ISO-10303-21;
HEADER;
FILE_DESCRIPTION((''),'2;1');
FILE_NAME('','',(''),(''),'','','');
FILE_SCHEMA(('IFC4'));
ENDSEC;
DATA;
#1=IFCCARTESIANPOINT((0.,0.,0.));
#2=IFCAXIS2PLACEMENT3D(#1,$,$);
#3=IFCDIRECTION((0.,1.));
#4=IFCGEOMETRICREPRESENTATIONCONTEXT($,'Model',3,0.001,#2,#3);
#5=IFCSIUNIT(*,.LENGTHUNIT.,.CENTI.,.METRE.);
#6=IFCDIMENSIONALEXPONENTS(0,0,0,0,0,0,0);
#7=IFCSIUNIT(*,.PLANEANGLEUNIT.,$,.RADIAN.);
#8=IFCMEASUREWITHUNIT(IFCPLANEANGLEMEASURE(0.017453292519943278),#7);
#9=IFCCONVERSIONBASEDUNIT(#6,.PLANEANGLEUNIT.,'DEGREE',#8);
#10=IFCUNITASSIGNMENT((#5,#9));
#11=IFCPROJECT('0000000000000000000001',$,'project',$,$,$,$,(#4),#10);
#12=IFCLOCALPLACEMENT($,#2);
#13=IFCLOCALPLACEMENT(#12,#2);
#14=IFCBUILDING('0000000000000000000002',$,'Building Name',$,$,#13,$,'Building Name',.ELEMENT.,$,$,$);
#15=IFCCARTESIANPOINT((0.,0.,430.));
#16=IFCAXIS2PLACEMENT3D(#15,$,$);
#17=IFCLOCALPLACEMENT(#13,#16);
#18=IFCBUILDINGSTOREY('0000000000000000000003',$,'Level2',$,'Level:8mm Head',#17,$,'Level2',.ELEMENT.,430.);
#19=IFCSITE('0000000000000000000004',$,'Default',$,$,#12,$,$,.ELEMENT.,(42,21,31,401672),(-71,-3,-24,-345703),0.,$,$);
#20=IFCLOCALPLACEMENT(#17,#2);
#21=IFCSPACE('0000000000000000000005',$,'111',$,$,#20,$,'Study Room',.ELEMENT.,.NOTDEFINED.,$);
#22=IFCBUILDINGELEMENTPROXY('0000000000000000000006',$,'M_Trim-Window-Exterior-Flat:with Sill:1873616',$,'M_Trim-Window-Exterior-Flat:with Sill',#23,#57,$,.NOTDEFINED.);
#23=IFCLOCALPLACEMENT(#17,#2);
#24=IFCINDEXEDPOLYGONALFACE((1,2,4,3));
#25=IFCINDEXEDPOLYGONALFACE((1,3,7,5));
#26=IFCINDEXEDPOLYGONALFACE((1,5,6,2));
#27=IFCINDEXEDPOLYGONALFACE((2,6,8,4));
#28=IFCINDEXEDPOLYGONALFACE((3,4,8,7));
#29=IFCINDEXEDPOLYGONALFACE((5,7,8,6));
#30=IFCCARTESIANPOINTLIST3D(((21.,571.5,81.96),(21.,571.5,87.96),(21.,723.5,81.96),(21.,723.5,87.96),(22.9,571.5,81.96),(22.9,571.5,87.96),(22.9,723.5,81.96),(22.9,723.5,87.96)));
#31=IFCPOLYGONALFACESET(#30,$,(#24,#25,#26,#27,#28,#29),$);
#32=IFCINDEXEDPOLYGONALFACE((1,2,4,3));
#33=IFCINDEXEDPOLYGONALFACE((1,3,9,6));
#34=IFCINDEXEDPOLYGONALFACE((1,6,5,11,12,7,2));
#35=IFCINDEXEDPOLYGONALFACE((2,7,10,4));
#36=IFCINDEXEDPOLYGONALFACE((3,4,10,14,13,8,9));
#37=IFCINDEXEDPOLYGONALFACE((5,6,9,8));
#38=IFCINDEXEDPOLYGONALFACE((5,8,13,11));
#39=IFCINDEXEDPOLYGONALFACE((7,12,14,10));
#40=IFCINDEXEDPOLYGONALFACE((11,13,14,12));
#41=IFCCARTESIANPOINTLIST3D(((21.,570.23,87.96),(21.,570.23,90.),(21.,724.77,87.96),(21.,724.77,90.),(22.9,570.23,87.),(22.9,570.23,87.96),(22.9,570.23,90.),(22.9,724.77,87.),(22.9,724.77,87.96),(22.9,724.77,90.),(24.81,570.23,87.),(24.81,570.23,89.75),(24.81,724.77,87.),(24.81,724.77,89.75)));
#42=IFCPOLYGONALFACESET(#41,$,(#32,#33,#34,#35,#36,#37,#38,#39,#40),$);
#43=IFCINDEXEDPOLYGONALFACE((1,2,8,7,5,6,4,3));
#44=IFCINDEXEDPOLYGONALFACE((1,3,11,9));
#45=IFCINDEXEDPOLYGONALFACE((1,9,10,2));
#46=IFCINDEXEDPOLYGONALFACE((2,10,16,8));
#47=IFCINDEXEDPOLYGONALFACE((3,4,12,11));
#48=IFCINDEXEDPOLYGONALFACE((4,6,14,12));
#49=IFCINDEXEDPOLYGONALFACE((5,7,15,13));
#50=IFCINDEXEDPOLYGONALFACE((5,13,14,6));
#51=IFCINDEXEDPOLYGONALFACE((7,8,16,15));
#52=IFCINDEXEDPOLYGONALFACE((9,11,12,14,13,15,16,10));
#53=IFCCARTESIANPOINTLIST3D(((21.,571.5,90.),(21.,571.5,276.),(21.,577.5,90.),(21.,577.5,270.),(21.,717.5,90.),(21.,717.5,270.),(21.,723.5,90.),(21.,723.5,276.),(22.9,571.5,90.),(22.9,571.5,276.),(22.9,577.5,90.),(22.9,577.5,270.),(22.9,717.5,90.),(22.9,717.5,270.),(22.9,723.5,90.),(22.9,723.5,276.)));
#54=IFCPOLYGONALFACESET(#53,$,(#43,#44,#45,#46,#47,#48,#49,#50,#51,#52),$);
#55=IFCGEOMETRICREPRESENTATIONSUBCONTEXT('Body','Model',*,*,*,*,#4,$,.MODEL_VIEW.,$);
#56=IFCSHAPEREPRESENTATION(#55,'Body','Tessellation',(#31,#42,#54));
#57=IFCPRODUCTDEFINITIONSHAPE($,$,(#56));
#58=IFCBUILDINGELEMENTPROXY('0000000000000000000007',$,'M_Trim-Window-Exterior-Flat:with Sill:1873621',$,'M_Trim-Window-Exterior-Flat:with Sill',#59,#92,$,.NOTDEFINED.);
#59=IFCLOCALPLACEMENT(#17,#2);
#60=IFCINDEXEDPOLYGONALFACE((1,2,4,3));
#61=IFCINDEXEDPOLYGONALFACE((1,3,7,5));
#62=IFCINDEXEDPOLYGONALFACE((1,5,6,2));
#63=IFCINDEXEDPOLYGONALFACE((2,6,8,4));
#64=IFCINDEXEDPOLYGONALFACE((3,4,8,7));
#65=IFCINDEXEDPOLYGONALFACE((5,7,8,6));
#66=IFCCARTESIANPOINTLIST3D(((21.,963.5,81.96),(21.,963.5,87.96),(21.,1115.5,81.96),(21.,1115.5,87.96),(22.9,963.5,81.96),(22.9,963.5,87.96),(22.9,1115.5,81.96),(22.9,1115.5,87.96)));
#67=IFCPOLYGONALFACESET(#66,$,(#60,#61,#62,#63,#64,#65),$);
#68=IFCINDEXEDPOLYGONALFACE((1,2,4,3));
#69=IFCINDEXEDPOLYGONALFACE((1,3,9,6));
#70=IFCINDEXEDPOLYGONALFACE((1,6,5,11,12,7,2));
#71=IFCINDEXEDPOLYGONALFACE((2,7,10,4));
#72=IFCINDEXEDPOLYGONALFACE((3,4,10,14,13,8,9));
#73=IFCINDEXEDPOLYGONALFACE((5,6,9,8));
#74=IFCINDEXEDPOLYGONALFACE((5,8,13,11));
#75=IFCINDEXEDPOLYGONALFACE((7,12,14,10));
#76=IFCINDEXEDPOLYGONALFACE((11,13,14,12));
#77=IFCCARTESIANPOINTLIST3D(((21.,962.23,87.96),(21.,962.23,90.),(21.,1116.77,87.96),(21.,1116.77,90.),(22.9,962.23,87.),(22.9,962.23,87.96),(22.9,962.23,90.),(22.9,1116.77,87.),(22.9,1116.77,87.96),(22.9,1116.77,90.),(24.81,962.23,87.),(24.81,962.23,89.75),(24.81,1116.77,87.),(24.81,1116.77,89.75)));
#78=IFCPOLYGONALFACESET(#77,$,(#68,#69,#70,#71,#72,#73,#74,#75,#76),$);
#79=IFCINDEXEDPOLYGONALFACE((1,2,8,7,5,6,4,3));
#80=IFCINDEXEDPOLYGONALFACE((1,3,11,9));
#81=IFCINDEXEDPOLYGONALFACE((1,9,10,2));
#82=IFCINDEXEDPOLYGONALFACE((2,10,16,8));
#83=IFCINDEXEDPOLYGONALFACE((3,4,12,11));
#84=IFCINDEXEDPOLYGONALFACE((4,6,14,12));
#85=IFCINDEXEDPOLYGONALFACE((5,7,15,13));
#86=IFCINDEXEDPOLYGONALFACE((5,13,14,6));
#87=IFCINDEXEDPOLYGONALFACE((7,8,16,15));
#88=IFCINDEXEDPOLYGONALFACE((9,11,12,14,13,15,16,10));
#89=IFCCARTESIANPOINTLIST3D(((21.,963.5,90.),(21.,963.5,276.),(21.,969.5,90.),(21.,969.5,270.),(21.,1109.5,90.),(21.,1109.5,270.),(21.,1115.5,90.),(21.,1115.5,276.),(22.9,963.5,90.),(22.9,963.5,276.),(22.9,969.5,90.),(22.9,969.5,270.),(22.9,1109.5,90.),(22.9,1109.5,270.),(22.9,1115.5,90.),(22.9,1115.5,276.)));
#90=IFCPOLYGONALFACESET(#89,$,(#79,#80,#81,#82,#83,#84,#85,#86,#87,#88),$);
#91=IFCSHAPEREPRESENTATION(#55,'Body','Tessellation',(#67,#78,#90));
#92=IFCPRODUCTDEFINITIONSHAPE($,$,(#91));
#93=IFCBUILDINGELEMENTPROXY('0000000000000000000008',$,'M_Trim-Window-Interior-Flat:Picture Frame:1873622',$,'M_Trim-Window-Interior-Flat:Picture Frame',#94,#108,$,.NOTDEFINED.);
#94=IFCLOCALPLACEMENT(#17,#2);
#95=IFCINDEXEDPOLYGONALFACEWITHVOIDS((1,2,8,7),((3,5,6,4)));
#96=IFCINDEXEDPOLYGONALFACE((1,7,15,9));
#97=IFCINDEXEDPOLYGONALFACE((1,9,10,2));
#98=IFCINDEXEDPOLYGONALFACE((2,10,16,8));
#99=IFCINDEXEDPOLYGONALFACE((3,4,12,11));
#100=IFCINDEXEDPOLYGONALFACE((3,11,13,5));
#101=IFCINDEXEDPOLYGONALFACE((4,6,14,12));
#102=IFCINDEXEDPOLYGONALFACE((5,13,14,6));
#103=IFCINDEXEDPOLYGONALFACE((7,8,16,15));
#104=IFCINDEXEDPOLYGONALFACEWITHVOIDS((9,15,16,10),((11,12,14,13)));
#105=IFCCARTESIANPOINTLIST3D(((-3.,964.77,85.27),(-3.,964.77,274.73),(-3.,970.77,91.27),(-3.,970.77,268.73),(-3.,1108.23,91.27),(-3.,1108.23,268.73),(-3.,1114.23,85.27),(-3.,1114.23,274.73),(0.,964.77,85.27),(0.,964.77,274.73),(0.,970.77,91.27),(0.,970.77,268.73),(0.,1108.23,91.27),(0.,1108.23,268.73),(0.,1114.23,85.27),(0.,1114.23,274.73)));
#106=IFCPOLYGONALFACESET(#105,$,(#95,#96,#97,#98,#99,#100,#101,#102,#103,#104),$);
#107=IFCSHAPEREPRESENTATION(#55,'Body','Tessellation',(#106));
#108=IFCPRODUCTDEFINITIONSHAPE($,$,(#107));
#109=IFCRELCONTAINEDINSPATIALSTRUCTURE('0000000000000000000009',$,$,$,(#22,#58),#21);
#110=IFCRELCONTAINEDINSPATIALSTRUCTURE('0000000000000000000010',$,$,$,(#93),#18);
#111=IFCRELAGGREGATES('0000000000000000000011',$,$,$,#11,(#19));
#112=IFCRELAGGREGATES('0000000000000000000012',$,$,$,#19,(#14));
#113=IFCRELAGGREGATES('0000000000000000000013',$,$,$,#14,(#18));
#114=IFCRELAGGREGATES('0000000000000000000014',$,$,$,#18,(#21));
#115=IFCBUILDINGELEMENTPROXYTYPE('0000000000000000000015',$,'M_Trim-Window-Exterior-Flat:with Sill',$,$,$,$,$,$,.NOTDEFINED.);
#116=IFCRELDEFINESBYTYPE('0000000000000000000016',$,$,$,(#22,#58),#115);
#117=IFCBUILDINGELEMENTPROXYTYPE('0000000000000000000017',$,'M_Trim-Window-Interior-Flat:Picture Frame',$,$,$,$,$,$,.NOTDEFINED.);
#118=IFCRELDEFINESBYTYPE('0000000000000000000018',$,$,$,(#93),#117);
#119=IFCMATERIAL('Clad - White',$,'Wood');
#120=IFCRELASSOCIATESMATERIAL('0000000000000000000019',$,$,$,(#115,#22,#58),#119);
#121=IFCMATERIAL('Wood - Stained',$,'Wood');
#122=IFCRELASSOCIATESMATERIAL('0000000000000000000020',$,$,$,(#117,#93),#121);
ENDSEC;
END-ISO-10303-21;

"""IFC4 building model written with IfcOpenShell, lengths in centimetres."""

from ifc_helpers import new_model, entity, si_unit, converted_unit, direction, frame, origin, place, context, subcontext, project, spatial, indexed_curve, outline, extrude, source, transform, mapped, material, type_object, type_shapes, element, save


model = new_model("IFC4")

# Units and contexts
model_context = context("Model", 3, precision=0.001, world=origin(), true_north=direction((0.0, 1.0)))
body_context = subcontext(model_context, "Body", "Model", "MODEL_VIEW")
ifc_project = project(units=[si_unit("LENGTHUNIT", "METRE", prefix="CENTI"), converted_unit("PLANEANGLEUNIT", "DEGREE", entity("IfcPlaneAngleMeasure", 0.017453292519943278), si_unit("PLANEANGLEUNIT", "RADIAN"), dimensions=[0, 0, 0, 0, 0, 0, 0])], contexts=[model_context])

# Site, building, storey
site_placement = place(None, origin())
site = spatial("IfcSite", under=ifc_project, at=site_placement, Name="Default", CompositionType="ELEMENT", RefLatitude=(42, 21, 31, 401672), RefLongitude=(-71, -3, -24, -345703), RefElevation=0.0)
building_placement = place(site_placement, origin())
building = spatial("IfcBuilding", under=site, at=building_placement, Name="Building Name", LongName="Building Name", CompositionType="ELEMENT")
storey_placement = place(building_placement, frame((0.0, 0.0, 430.0)))
storey = spatial("IfcBuildingStorey", under=building, at=storey_placement, Name="Level2", ObjectType="Level:8mm Head", LongName="Level2", CompositionType="ELEMENT", Elevation=430.0)

# Shared definitions
space_placement = place(storey_placement, origin())
space = spatial("IfcSpace", under=storey, at=space_placement, Name="111", LongName="Study Room", CompositionType="ELEMENT", PredefinedType="NOTDEFINED")

# Building element proxies
ifc_material_1 = material(Name="Clad - White", Category="Wood")
ifc_material_2 = material(Name="Wood - Stained", Category="Wood")
building_element_proxy_type_1 = type_object("IfcBuildingElementProxyType", Name="M_Trim-Window-Exterior-Flat:with Sill", PredefinedType="NOTDEFINED", material=ifc_material_1)
shared_shape_1 = source(origin(), body_context, "Body", "SweptSolid", [
    extrude(outline(indexed_curve([(-76.0, -3.0), (76.0, -3.0), (76.0, 3.0), (-76.0, 3.0), (-76.0, -3.0)], self_intersect=False)), frame((0.0, -185.04, 0.0), z_axis=(0.0, 0.0, 1.0), x_axis=(-1.0, 0.0, 0.0)), (0.0, 0.0, 1.0), 1.9),
    extrude(outline(indexed_curve([(-1.9, -1.52), (0.0, -1.52), (0.0, -0.57), (1.9, -0.57), (1.9, 1.48), (0.0, 1.48), (-1.9, 1.23), (-1.9, -1.52)], self_intersect=False)), frame((-77.27, -181.48, 1.9), z_axis=(1.0, 0.0, 0.0), x_axis=(0.0, 0.0, -1.0)), (0.0, 0.0, 1.0), 154.54),
    extrude(outline(indexed_curve([(-94.5, -76.0), (91.5, -76.0), (91.5, -70.0), (-88.5, -70.0), (-88.5, 70.0), (91.5, 70.0), (91.5, 76.0), (-94.5, 76.0), (-94.5, -76.0)], self_intersect=False)), frame((0.0, -88.5, 0.0), z_axis=(0.0, 0.0, 1.0), x_axis=(0.0, -1.0, 0.0)), (0.0, 0.0, 1.0), 1.9),
])
type_shapes(building_element_proxy_type_1, [shared_shape_1])
for number, where, z_axis, x_axis, name in (
    (1, (21.0, 647.5, 270.0), (1.0, 0.0, 0.0), (0.0, 1.0, 0.0), "M_Trim-Window-Exterior-Flat:with Sill:1873616"),
    (2, (21.0, 1039.5, 270.0), (1.0, 0.0, 0.0), (0.0, 1.0, 0.0), "M_Trim-Window-Exterior-Flat:with Sill:1873621"),
):
    element("IfcBuildingElementProxy", number, at=place(space_placement, frame(where, z_axis=z_axis, x_axis=x_axis)), inside=space, type_object=building_element_proxy_type_1, material=ifc_material_1, Name=name, ObjectType="M_Trim-Window-Exterior-Flat:with Sill", PredefinedType="NOTDEFINED", context=body_context, shape_type="MappedRepresentation", body=[
        mapped(shared_shape_1, transform((0.0, 0.0, 0.0), scale=1.0)),
    ])
building_element_proxy_type_2 = type_object("IfcBuildingElementProxyType", Name="M_Trim-Window-Interior-Flat:Picture Frame", PredefinedType="NOTDEFINED", material=ifc_material_2)
shared_shape_2 = source(origin(), body_context, "Body", "SweptSolid", [
    extrude(outline(indexed_curve([(-74.73, -94.73), (74.73, -94.73), (74.73, 94.73), (-74.73, 94.73), (-74.73, -94.73)], self_intersect=False), holes=[indexed_curve([(-68.73, -88.73), (-68.73, 88.73), (68.73, 88.73), (68.73, -88.73), (-68.73, -88.73)], self_intersect=False)]), frame((0.0, -90.0, 0.0), z_axis=(0.0, 0.0, 1.0), x_axis=(-1.0, 0.0, 0.0)), (0.0, 0.0, 1.0), 3.0),
])
type_shapes(building_element_proxy_type_2, [shared_shape_2])
proxy_1_placement = place(storey_placement, frame((0.0, 1039.5, 270.0), z_axis=(-1.0, 0.0, 0.0), x_axis=(0.0, -1.0, 0.0)))
element("IfcBuildingElementProxy", 3, at=proxy_1_placement, inside=storey, type_object=building_element_proxy_type_2, material=ifc_material_2, Name="M_Trim-Window-Interior-Flat:Picture Frame:1873622", ObjectType="M_Trim-Window-Interior-Flat:Picture Frame", PredefinedType="NOTDEFINED", context=body_context, shape_type="MappedRepresentation", body=[
    mapped(shared_shape_2, transform((0.0, 0.0, 0.0), scale=1.0)),
])

save(model, "model.ifc")
